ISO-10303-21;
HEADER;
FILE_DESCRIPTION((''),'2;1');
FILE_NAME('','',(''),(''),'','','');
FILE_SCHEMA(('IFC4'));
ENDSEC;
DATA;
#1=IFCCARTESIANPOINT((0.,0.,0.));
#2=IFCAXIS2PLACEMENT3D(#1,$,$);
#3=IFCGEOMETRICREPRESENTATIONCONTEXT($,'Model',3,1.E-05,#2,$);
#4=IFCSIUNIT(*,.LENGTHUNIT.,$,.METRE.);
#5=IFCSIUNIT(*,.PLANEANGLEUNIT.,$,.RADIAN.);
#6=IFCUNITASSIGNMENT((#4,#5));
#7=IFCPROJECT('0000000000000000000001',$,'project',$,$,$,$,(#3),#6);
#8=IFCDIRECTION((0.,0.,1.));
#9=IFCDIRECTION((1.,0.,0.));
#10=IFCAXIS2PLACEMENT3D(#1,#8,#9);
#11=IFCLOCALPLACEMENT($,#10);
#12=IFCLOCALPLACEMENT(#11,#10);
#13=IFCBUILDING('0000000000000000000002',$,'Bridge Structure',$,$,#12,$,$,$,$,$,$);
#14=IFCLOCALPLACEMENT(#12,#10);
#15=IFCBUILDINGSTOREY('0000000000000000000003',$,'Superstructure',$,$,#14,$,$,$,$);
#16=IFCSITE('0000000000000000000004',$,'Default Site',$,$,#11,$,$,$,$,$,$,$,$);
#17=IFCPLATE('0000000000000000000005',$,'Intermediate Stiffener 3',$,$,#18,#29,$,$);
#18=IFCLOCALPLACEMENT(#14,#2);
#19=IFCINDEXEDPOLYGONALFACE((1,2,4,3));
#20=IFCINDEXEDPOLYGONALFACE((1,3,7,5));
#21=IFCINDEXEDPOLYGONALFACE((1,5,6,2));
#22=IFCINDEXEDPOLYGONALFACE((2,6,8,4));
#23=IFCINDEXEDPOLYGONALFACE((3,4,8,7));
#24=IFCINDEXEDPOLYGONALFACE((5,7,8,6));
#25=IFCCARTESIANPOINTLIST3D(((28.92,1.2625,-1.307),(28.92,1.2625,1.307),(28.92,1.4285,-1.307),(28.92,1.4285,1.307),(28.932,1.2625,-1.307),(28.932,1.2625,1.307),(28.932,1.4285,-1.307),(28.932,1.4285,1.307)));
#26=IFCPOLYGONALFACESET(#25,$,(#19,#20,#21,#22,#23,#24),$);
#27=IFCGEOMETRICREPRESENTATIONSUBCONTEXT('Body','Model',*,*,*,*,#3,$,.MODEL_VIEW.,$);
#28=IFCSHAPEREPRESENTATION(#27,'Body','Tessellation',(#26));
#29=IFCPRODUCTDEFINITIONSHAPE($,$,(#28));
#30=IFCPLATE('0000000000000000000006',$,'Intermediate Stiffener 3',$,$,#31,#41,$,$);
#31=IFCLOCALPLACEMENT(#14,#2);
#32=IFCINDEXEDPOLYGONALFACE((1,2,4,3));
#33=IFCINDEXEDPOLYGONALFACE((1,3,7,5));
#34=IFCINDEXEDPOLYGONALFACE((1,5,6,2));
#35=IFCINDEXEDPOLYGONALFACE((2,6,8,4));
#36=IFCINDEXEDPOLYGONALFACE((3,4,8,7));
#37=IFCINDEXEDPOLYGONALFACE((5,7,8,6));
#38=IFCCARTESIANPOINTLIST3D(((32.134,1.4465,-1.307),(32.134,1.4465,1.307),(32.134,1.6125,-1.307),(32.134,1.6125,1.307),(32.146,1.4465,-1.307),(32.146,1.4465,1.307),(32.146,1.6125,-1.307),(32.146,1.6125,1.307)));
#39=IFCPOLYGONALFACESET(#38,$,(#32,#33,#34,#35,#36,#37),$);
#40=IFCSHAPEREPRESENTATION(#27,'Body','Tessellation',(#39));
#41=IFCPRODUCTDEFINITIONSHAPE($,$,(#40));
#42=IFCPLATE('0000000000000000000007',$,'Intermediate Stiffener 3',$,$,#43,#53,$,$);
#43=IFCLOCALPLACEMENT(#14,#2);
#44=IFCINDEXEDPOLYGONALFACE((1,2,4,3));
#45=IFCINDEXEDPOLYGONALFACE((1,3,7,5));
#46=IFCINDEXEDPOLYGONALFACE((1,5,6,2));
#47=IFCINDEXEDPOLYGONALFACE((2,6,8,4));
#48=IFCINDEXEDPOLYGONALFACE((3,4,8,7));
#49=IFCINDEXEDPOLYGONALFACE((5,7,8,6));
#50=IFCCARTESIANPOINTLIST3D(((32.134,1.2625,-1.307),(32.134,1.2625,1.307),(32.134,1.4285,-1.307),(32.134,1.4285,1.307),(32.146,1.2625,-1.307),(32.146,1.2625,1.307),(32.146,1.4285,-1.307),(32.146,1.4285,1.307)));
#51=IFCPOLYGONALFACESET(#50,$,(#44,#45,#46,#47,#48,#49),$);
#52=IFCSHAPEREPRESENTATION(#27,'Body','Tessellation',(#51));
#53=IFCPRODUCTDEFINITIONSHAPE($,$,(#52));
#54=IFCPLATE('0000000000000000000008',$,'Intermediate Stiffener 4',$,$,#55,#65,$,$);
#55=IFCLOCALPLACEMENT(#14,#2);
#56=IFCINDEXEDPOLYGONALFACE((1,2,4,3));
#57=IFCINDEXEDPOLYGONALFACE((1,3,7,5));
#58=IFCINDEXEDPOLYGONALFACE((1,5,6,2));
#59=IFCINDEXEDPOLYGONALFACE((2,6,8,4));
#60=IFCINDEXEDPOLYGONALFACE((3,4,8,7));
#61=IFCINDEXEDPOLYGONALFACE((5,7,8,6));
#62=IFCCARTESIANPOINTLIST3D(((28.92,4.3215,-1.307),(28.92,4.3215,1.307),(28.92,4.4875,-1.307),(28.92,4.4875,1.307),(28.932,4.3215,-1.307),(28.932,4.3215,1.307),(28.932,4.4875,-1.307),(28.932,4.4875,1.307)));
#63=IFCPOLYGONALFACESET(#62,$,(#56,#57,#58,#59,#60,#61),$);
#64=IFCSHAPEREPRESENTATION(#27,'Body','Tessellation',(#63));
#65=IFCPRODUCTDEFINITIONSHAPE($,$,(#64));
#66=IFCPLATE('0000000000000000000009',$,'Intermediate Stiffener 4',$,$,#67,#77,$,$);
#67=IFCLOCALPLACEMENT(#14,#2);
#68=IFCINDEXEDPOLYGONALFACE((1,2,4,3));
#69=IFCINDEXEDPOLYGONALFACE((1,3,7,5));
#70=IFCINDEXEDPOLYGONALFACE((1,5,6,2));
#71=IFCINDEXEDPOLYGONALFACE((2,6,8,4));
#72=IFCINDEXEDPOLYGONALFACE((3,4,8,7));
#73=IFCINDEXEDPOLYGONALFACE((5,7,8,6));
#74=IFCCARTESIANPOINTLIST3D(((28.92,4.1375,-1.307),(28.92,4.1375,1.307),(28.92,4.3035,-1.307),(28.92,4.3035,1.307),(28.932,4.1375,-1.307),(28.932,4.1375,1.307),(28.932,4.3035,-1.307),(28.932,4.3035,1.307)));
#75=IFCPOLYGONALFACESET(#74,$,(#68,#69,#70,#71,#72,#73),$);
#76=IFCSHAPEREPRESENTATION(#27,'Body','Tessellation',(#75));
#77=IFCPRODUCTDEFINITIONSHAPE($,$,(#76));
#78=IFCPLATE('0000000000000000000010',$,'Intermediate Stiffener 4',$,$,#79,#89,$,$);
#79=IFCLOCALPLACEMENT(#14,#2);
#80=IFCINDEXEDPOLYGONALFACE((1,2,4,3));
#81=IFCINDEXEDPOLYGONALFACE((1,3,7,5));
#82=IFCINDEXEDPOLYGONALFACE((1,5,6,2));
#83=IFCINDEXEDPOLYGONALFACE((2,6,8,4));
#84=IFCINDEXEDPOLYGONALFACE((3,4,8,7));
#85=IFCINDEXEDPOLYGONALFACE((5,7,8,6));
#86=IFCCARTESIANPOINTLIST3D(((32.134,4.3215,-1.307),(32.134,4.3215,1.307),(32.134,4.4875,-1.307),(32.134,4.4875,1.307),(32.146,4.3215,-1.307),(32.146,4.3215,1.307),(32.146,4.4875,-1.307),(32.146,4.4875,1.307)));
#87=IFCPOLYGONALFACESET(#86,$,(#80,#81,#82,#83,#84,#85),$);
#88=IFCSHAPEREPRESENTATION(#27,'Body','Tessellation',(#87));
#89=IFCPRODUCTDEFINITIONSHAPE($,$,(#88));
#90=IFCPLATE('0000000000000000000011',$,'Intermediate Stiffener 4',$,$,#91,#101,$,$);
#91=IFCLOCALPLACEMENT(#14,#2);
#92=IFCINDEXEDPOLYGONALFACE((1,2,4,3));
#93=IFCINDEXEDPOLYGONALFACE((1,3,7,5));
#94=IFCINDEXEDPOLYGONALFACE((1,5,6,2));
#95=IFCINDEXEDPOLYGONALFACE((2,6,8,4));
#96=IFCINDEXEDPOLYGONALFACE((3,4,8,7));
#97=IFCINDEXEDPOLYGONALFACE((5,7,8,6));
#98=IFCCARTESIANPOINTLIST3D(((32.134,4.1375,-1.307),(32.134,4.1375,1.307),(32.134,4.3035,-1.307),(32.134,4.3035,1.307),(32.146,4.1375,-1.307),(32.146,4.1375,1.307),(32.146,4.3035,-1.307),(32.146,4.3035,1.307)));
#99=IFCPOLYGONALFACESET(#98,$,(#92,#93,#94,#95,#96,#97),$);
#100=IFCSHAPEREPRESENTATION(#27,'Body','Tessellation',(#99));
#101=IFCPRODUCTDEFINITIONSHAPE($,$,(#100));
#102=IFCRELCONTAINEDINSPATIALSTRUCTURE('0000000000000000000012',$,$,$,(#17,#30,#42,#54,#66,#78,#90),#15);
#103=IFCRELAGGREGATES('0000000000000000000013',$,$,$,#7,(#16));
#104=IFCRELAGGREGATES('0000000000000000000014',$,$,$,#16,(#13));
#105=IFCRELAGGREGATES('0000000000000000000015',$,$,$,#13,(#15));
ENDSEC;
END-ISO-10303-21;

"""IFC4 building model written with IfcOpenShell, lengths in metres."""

from ifc_helpers import new_model, si_unit, frame, origin, origin_with_axes, origin_2d_with_axis, place, context, subcontext, project, spatial, rectangle, extrude, element, save


model = new_model("IFC4")

# Units and contexts
model_context = context("Model", 3, precision=1e-05, world=origin())
body_context = subcontext(model_context, "Body", "Model", "MODEL_VIEW")
ifc_project = project(units=[si_unit("LENGTHUNIT", "METRE"), si_unit("PLANEANGLEUNIT", "RADIAN")], contexts=[model_context])

# Site, building, storey
site_placement = place(None, origin_with_axes())
site = spatial("IfcSite", under=ifc_project, at=site_placement, Name="Default Site")
building_placement = place(site_placement, origin_with_axes())
building = spatial("IfcBuilding", under=site, at=building_placement, Name="Bridge Structure")
storey_placement = place(building_placement, origin_with_axes())
storey = spatial("IfcBuildingStorey", under=building, at=storey_placement, Name="Superstructure")

# Plates
for number, where, z_axis, x_axis, name in (
    (1, (28.926, 1.3455, -1.307), (0.0, 0.0, 1.0), (1.0, 0.0, 0.0), "Intermediate Stiffener 3"),
    (2, (32.14, 1.5295, -1.307), (0.0, 0.0, 1.0), (1.0, 0.0, 0.0), "Intermediate Stiffener 3"),
    (3, (32.14, 1.3455, -1.307), (0.0, 0.0, 1.0), (1.0, 0.0, 0.0), "Intermediate Stiffener 3"),
    (4, (28.926, 4.4045, -1.307), (0.0, 0.0, 1.0), (1.0, 0.0, 0.0), "Intermediate Stiffener 4"),
    (5, (28.926, 4.2205, -1.307), (0.0, 0.0, 1.0), (1.0, 0.0, 0.0), "Intermediate Stiffener 4"),
    (6, (32.14, 4.4045, -1.307), (0.0, 0.0, 1.0), (1.0, 0.0, 0.0), "Intermediate Stiffener 4"),
    (7, (32.14, 4.2205, -1.307), (0.0, 0.0, 1.0), (1.0, 0.0, 0.0), "Intermediate Stiffener 4"),
):
    element("IfcPlate", number, at=place(storey_placement, frame(where, z_axis=z_axis, x_axis=x_axis)), inside=storey, Name=name, context=body_context, shape_type="SweptSolid", body=[
        extrude(rectangle(XDim=0.012, YDim=0.166, at=origin_2d_with_axis()), origin_with_axes(), (0.0, 0.0, 1.0), 2.614),
    ])

save(model, "model.ifc")
